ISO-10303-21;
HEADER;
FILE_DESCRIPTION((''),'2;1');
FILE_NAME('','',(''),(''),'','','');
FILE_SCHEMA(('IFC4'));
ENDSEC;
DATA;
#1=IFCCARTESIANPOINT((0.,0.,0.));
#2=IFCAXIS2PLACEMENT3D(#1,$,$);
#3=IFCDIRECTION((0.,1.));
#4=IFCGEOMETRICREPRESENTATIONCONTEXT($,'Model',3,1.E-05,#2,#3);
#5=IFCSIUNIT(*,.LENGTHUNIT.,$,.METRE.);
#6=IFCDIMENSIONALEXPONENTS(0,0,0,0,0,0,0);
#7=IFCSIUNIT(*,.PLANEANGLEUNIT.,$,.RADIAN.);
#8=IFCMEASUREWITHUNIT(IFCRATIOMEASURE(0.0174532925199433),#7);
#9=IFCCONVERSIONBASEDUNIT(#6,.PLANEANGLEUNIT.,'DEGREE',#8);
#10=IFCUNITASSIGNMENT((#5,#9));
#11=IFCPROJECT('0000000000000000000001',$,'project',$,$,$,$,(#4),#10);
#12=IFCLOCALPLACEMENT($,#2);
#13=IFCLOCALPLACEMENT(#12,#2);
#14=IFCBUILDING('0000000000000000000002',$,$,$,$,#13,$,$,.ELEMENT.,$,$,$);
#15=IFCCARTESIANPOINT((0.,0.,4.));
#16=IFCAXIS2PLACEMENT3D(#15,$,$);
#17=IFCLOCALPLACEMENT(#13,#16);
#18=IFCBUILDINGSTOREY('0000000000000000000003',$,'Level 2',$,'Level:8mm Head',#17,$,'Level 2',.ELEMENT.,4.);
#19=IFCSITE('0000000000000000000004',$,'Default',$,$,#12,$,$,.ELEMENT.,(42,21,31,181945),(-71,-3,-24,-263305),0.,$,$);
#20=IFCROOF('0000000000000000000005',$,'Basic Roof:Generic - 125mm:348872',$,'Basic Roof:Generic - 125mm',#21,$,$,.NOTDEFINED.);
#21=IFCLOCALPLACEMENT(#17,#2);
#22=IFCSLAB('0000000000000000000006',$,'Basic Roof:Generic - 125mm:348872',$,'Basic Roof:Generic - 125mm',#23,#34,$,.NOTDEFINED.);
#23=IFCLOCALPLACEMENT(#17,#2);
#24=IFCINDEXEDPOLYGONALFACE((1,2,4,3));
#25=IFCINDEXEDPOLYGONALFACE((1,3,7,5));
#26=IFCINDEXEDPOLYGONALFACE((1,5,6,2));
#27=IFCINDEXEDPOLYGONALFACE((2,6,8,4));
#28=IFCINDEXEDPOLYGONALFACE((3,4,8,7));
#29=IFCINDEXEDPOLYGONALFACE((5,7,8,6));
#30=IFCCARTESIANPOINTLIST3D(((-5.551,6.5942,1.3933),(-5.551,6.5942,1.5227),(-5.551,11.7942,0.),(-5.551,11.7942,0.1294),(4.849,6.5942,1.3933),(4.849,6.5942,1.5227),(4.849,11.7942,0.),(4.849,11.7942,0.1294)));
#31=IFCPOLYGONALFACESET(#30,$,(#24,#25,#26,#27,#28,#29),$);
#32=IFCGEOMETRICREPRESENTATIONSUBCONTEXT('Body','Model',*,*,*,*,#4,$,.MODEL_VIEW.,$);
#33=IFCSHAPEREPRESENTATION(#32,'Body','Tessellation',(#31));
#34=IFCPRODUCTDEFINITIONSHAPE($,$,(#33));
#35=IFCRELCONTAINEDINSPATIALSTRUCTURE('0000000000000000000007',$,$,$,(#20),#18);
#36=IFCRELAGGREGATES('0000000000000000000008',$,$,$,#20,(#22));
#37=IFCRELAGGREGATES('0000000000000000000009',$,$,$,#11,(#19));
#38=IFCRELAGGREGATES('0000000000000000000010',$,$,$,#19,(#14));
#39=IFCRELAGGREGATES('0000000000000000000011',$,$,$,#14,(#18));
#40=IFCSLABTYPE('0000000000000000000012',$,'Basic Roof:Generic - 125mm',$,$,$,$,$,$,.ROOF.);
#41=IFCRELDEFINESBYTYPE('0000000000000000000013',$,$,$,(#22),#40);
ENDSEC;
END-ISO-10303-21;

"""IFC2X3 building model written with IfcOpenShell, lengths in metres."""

from ifc_helpers import new_model, entity, si_unit, converted_unit, direction, frame, frame_2d, origin, place, context, subcontext, project, spatial, rectangle, extrude, type_object, element, aggregate, save


model = new_model("IFC2X3")

# Units and contexts
model_context = context("Model", 3, precision=1e-05, world=origin(), true_north=direction((0.0, 1.0)))
body_context = subcontext(model_context, "Body", "Model", "MODEL_VIEW")
ifc_project = project(units=[si_unit("LENGTHUNIT", "METRE"), converted_unit("PLANEANGLEUNIT", "DEGREE", entity("IfcRatioMeasure", 0.0174532925199433), si_unit("PLANEANGLEUNIT", "RADIAN"), dimensions=[0, 0, 0, 0, 0, 0, 0])], contexts=[model_context])

# Site, building, storey
site_placement = place(None, origin())
site = spatial("IfcSite", under=ifc_project, at=site_placement, Name="Default", CompositionType="ELEMENT", RefLatitude=(42, 21, 31, 181945), RefLongitude=(-71, -3, -24, -263305), RefElevation=0.0)
building_placement = place(site_placement, origin())
building = spatial("IfcBuilding", under=site, at=building_placement, CompositionType="ELEMENT")
storey_placement = place(building_placement, frame((0.0, 0.0, 4.0)))
storey = spatial("IfcBuildingStorey", under=building, at=storey_placement, Name="Level 2", ObjectType="Level:8mm Head", LongName="Level 2", CompositionType="ELEMENT", Elevation=4.0)

# Roof, slab
roof_placement = place(storey_placement, frame((-5.551, 6.5942, 0.0)))
roof = element("IfcRoof", 1, at=roof_placement, inside=storey, Name="Basic Roof:Generic - 125mm:348872", ObjectType="Basic Roof:Generic - 125mm", ShapeType="NOTDEFINED")
slab_type = type_object("IfcSlabType", Name="Basic Roof:Generic - 125mm", PredefinedType="ROOF")
slab_placement = place(roof_placement, origin())
slab = element("IfcSlab", 2, at=slab_placement, type_object=slab_type, Name="Basic Roof:Generic - 125mm:348872", ObjectType="Basic Roof:Generic - 125mm", PredefinedType="NOTDEFINED", context=body_context, shape_type="SweptSolid", body=[
    extrude(rectangle(XDim=10.4, YDim=5.3834, at=frame_2d((0.0, 0.0), x_axis=(-1.0, 0.0))), frame((5.2, 2.6, 0.6967), z_axis=(0.0, 0.258819, 0.965926), x_axis=(1.0, 0.0, 0.0)), (0.0, -0.258819, 0.965926), 0.1294),
])
aggregate(roof, [slab])

save(model, "model.ifc")
